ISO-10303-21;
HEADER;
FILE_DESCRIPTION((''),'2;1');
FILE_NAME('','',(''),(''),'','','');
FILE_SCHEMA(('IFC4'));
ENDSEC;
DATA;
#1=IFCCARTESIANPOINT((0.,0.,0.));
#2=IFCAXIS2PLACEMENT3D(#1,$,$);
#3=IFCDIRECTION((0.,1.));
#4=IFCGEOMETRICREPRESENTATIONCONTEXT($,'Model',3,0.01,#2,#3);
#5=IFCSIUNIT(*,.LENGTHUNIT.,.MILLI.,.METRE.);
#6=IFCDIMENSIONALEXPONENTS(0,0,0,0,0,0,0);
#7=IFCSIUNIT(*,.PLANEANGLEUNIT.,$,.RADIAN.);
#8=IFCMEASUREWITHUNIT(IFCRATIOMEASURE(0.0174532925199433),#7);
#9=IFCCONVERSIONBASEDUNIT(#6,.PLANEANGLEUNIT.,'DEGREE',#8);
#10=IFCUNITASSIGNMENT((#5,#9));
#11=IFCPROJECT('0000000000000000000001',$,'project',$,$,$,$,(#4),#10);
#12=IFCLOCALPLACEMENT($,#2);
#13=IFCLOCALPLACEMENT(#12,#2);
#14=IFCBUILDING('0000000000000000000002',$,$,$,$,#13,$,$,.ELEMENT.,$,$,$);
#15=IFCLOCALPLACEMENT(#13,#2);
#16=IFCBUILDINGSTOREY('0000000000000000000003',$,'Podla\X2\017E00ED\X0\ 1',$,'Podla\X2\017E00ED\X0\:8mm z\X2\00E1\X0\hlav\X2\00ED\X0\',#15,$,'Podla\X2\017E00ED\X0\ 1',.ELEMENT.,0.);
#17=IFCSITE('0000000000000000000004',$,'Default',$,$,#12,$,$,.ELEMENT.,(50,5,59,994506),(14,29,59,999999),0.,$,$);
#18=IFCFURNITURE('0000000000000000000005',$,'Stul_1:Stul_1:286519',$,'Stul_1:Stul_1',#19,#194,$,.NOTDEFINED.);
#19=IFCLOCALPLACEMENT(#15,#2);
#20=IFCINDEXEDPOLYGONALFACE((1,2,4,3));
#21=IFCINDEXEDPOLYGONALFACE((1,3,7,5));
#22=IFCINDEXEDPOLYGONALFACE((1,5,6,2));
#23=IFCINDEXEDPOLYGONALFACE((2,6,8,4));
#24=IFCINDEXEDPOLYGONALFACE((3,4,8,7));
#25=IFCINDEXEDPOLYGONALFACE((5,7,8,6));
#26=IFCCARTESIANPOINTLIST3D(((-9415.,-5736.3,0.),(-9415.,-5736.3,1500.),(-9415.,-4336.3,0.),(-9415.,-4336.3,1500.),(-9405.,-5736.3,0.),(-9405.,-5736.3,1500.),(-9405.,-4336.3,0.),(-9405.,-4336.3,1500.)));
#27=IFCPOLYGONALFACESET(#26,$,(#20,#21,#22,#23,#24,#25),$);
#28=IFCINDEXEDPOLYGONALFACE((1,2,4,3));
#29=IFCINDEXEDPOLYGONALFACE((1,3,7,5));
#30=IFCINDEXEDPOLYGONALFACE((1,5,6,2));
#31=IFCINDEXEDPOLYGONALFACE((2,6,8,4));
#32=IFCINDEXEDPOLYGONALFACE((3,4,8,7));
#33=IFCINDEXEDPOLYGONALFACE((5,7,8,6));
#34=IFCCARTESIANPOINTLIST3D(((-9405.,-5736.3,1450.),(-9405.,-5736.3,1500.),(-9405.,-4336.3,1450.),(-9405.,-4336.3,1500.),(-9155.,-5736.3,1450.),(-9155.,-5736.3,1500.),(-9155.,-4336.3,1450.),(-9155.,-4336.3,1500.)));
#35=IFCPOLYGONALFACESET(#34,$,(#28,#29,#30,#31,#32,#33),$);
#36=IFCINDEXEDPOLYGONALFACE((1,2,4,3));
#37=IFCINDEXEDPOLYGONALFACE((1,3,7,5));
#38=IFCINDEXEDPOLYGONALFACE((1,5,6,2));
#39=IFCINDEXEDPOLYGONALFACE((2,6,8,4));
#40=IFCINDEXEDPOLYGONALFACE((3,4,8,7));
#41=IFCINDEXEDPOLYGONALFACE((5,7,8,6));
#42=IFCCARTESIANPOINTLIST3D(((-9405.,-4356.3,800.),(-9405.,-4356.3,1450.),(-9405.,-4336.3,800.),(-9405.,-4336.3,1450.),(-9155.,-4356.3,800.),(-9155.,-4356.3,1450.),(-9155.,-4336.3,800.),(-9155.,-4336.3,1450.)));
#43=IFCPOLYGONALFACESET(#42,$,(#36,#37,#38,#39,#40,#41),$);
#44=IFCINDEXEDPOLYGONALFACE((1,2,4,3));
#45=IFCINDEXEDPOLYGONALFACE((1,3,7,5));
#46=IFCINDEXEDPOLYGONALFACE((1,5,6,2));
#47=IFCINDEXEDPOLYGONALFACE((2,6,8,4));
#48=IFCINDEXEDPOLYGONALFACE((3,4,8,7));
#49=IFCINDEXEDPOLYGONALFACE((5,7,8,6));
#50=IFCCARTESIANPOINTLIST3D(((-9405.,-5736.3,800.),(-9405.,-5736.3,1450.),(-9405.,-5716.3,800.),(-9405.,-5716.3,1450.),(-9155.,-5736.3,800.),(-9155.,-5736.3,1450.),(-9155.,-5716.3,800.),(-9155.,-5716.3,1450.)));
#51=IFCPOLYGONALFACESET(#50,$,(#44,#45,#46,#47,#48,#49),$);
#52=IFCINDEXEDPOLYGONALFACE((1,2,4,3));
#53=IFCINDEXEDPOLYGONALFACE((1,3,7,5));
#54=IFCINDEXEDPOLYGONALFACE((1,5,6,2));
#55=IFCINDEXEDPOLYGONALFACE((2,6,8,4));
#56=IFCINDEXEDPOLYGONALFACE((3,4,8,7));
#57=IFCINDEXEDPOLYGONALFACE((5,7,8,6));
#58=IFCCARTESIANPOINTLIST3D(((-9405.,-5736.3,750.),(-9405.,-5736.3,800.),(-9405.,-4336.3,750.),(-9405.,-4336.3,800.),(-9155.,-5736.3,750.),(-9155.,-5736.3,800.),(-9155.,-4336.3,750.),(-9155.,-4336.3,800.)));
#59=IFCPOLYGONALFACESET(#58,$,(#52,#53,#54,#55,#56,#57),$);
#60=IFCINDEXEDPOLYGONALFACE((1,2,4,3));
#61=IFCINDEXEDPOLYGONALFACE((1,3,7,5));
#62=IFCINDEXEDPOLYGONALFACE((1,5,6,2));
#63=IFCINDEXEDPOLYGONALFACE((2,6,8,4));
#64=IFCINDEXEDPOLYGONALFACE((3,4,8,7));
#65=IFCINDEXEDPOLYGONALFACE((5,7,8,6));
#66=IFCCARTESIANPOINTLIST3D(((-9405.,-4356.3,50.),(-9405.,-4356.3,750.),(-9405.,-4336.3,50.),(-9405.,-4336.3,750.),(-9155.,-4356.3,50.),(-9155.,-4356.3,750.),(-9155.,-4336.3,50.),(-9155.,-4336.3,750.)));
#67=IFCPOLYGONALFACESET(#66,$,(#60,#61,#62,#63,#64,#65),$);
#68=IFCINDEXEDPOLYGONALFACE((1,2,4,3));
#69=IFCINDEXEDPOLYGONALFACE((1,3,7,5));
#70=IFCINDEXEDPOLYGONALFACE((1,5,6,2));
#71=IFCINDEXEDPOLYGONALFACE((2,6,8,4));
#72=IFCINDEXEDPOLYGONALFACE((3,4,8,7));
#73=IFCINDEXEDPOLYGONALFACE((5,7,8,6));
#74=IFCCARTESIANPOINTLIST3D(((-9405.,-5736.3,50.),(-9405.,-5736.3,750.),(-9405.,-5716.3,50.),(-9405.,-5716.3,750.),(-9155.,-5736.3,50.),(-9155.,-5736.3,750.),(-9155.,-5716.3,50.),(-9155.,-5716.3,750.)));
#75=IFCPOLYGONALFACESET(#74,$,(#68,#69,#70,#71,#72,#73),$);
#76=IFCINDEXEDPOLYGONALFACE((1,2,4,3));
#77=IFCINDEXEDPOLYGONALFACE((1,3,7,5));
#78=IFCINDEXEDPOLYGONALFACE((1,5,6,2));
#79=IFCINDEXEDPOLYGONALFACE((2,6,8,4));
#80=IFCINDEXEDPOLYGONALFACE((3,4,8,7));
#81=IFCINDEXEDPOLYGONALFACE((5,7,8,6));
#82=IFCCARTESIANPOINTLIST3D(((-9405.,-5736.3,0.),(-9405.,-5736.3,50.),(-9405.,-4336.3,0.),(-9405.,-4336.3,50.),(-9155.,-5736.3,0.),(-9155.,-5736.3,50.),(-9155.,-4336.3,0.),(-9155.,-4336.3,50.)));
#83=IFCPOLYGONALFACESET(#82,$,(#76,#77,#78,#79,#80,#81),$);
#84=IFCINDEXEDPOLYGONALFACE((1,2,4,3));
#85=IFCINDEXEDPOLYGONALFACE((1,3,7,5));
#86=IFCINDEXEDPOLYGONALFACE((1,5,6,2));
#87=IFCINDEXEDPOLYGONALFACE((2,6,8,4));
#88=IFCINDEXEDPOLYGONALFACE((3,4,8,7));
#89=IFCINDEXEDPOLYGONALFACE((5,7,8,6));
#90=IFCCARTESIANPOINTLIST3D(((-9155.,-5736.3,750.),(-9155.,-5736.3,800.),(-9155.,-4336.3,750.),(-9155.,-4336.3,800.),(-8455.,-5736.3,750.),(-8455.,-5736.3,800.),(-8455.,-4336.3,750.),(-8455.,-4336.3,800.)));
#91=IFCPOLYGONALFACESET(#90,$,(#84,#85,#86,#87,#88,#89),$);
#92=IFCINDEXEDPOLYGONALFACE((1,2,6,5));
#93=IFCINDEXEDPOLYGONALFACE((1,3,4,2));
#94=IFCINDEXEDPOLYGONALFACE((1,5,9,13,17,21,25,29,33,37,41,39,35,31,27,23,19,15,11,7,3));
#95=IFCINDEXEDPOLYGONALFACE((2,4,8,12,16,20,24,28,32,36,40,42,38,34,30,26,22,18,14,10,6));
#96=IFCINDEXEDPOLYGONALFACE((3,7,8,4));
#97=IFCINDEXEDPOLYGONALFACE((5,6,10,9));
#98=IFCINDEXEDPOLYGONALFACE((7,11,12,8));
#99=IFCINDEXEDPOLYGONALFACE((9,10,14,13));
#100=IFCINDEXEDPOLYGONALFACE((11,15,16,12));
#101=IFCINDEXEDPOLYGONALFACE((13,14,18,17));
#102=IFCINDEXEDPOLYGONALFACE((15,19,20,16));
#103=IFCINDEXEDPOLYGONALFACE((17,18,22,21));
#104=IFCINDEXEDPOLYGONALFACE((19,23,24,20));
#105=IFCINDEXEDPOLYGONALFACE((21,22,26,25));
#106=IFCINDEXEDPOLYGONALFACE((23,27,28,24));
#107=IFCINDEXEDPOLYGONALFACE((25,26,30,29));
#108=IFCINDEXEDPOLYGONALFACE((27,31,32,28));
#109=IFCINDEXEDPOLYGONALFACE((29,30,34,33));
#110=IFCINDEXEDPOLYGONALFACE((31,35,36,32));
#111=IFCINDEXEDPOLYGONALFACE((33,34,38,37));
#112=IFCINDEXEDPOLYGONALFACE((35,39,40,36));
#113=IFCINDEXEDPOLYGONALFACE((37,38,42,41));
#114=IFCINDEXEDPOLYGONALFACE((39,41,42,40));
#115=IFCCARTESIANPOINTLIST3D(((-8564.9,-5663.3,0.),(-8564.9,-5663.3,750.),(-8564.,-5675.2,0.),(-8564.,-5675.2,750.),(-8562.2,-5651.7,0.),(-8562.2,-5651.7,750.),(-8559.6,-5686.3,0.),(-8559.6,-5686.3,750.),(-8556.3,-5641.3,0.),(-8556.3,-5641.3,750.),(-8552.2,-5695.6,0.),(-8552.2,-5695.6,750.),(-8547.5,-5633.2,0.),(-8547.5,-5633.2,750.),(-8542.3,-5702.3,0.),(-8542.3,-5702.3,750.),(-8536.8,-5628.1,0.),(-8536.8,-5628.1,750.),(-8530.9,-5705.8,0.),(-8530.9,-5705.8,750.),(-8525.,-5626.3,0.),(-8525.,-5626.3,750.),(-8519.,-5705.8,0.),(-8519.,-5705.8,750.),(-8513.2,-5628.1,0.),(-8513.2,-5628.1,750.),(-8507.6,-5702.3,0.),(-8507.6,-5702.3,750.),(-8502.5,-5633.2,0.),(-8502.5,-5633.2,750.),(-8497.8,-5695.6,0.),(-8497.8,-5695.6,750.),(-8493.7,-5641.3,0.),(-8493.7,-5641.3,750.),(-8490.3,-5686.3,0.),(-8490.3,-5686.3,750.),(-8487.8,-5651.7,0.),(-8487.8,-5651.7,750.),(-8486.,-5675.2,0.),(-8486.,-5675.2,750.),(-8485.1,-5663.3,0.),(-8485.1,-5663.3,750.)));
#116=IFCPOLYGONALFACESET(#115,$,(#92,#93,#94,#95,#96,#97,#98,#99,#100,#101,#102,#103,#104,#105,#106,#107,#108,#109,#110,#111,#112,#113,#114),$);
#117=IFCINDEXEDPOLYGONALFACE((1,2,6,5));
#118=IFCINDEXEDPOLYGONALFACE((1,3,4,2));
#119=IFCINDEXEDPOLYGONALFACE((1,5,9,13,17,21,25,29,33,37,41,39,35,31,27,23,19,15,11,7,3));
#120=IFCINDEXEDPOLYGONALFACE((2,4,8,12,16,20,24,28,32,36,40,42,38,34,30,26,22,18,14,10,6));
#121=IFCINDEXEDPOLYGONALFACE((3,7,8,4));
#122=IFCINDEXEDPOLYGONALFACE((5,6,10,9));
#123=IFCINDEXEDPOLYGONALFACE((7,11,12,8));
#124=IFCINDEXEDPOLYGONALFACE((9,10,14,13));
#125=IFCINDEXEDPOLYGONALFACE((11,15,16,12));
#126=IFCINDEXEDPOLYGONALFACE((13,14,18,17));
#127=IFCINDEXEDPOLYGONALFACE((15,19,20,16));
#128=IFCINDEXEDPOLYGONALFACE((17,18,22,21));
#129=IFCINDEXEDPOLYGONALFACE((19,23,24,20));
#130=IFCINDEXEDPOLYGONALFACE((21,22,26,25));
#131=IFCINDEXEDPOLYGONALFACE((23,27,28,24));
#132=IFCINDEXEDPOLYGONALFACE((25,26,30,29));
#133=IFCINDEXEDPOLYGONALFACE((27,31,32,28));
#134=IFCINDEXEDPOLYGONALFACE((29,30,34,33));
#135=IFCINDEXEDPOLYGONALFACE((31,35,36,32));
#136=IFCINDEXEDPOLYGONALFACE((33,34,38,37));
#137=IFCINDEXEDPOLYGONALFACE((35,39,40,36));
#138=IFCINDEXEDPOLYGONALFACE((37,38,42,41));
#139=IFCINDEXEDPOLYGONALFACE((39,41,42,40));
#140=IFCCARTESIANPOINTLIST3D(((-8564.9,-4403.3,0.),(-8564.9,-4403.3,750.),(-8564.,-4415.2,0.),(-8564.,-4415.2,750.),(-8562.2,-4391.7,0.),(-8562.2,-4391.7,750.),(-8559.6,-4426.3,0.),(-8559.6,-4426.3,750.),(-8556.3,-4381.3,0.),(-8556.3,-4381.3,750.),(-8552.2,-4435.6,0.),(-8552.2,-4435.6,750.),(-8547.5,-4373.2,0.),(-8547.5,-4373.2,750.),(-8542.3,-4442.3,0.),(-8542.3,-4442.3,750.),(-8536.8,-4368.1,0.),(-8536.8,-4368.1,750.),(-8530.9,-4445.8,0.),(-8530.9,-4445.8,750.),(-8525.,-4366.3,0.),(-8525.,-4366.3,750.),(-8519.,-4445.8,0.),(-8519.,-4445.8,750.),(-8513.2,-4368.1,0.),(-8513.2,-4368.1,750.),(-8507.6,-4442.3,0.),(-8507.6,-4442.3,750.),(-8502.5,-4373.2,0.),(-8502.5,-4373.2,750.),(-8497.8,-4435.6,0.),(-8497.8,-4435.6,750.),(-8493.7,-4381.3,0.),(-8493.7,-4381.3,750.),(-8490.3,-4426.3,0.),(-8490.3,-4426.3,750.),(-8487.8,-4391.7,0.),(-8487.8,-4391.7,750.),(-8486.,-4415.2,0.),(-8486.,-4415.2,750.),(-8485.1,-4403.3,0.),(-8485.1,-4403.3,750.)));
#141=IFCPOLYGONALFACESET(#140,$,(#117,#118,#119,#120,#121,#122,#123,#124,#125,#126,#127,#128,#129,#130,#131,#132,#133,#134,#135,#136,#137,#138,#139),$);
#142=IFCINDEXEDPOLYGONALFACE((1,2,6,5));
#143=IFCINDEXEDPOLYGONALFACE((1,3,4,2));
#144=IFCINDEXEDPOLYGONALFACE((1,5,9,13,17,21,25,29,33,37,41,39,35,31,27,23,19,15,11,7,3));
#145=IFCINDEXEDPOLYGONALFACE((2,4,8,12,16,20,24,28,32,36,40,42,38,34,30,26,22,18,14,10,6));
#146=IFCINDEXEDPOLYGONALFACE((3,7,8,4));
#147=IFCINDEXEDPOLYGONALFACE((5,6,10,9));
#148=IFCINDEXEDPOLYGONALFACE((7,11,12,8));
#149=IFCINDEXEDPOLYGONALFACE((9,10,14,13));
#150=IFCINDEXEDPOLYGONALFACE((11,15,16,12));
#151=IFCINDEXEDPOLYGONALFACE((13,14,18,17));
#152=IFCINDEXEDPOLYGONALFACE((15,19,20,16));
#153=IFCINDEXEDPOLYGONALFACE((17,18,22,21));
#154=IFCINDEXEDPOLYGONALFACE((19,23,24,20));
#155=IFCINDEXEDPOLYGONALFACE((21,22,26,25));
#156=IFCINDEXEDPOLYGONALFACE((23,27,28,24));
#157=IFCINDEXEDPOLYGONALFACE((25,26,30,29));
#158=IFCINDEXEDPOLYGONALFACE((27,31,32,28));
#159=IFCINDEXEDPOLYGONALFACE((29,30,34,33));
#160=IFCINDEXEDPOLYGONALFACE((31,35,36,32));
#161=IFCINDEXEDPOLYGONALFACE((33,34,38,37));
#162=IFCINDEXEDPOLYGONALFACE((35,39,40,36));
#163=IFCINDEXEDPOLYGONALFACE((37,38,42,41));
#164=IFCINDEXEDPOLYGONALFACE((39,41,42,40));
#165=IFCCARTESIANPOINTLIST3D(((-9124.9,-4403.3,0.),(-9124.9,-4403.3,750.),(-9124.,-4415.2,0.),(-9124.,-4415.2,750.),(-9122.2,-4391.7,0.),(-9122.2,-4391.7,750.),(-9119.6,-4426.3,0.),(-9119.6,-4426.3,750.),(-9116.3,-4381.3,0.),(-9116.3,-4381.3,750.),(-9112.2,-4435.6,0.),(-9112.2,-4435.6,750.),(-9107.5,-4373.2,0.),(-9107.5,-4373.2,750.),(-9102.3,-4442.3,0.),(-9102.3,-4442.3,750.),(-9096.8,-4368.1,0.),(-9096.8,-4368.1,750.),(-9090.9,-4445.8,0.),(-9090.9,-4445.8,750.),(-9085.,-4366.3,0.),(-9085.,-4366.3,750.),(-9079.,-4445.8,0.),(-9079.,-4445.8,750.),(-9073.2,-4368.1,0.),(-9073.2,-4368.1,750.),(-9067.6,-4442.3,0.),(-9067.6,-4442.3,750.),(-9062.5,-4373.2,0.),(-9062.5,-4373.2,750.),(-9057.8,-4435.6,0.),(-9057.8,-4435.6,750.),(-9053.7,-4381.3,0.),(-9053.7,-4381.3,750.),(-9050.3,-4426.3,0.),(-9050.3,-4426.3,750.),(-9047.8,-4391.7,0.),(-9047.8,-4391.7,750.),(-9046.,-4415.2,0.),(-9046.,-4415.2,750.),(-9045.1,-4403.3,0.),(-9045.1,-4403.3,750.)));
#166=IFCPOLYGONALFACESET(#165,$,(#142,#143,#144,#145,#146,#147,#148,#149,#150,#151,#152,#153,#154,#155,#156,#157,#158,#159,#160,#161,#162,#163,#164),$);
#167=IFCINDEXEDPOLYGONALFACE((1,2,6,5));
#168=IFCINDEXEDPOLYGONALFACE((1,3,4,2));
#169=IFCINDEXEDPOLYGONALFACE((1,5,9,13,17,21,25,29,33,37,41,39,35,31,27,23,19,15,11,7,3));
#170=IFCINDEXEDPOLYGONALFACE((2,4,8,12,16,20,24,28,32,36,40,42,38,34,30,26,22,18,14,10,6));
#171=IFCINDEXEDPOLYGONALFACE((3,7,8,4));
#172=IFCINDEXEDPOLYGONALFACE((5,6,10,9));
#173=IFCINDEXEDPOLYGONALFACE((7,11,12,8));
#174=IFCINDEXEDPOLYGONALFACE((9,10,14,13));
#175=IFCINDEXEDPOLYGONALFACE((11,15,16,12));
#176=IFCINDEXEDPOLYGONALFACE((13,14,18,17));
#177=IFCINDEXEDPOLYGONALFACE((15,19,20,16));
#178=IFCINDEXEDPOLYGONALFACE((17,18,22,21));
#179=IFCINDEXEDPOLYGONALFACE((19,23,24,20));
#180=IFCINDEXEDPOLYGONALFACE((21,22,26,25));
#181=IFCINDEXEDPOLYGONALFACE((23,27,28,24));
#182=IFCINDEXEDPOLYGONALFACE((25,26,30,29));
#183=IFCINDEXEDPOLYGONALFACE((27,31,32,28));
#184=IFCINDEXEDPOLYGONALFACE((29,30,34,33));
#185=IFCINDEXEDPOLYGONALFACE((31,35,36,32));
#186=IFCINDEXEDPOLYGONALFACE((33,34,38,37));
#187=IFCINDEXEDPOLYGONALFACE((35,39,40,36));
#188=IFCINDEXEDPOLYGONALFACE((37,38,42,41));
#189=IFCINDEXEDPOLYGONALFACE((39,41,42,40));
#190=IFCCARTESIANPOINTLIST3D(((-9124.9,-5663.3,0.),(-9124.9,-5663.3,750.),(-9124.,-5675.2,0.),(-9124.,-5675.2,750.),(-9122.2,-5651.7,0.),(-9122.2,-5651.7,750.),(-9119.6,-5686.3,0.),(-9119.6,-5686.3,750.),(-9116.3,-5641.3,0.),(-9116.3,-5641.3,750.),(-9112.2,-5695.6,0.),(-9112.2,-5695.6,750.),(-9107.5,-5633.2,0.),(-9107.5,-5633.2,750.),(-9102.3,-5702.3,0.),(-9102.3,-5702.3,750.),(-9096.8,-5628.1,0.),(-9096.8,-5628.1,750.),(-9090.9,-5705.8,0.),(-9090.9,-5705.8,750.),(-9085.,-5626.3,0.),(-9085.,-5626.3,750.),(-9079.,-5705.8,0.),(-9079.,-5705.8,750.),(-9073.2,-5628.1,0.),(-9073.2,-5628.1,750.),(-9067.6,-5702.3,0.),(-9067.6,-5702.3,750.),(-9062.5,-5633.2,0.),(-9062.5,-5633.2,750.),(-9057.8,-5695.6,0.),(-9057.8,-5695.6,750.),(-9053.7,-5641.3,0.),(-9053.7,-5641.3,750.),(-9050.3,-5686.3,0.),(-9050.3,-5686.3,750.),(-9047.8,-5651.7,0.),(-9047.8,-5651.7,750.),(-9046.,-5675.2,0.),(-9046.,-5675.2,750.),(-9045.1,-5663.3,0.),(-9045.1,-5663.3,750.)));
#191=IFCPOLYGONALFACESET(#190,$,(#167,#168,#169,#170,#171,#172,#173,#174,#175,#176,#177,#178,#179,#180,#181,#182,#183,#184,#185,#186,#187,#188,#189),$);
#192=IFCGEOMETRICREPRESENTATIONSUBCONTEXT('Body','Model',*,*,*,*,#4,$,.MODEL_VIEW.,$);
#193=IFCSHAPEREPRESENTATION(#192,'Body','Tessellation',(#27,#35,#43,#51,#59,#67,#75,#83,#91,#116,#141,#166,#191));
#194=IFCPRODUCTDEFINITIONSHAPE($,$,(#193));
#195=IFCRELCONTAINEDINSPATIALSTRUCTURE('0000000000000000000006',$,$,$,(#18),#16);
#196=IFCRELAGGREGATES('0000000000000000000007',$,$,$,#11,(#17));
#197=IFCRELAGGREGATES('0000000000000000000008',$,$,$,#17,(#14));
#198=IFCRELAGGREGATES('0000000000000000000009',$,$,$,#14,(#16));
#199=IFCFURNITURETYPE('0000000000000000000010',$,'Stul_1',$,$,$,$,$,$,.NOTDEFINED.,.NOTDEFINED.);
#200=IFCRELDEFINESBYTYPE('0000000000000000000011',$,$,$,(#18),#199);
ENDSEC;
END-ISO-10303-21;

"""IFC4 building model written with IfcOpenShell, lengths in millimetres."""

from ifc_helpers import new_model, entity, si_unit, converted_unit, direction, frame, frame_2d, origin, origin_2d_with_axis, place, context, subcontext, project, spatial, rectangle, circle, extrude, source, transform, mapped, type_object, type_shapes, element, save


model = new_model("IFC4")

# Units and contexts
model_context = context("Model", 3, precision=0.01, world=origin(), true_north=direction((0.0, 1.0)))
body_context = subcontext(model_context, "Body", "Model", "MODEL_VIEW")
ifc_project = project(units=[si_unit("LENGTHUNIT", "METRE", prefix="MILLI"), converted_unit("PLANEANGLEUNIT", "DEGREE", entity("IfcRatioMeasure", 0.0174532925199433), si_unit("PLANEANGLEUNIT", "RADIAN"), dimensions=[0, 0, 0, 0, 0, 0, 0])], contexts=[model_context])

# Site, building, storey
site_placement = place(None, origin())
site = spatial("IfcSite", under=ifc_project, at=site_placement, Name="Default", CompositionType="ELEMENT", RefLatitude=(50, 5, 59, 994506), RefLongitude=(14, 29, 59, 999999), RefElevation=0.0)
building_placement = place(site_placement, origin())
building = spatial("IfcBuilding", under=site, at=building_placement, CompositionType="ELEMENT")
storey_placement = place(building_placement, origin())
storey = spatial("IfcBuildingStorey", under=building, at=storey_placement, Name="Podlaží 1", ObjectType="Podlaží:8mm záhlaví", LongName="Podlaží 1", CompositionType="ELEMENT", Elevation=0.0)

# Furniture
furniture_type = type_object("IfcFurnitureType", Name="Stul_1", AssemblyPlace="NOTDEFINED", PredefinedType="NOTDEFINED")
shared_shape_1 = source(origin(), body_context, "Body", "SweptSolid", [
    extrude(rectangle(XDim=1400.0, YDim=10.0, at=origin_2d_with_axis()), frame((0.0, 605.0, 0.0), z_axis=(0.0, 0.0, 1.0), x_axis=(-1.0, 0.0, 0.0)), (0.0, 0.0, 1.0), 1500.0),
    extrude(rectangle(XDim=1400.0, YDim=250.0, at=frame_2d((0.0, 0.0), x_axis=(1.0, 0.0))), frame((0.0, 475.0, 1450.0), z_axis=(0.0, 0.0, 1.0), x_axis=(-1.0, 0.0, 0.0)), (0.0, 0.0, 1.0), 50.0),
    extrude(rectangle(XDim=20.0, YDim=250.0, at=origin_2d_with_axis()), frame((690.0, 475.0, 800.0), z_axis=(0.0, 0.0, 1.0), x_axis=(-1.0, 0.0, 0.0)), (0.0, 0.0, 1.0), 650.0),
    extrude(rectangle(XDim=20.0, YDim=250.0, at=frame_2d((0.0, 0.0), x_axis=(1.0, 0.0))), frame((-690.0, 475.0, 800.0), z_axis=(0.0, 0.0, 1.0), x_axis=(-1.0, 0.0, 0.0)), (0.0, 0.0, 1.0), 650.0),
    extrude(rectangle(XDim=1400.0, YDim=250.0, at=origin_2d_with_axis()), frame((0.0, 475.0, 750.0), z_axis=(0.0, 0.0, 1.0), x_axis=(-1.0, 0.0, 0.0)), (0.0, 0.0, 1.0), 50.0),
    extrude(rectangle(XDim=20.0, YDim=250.0, at=origin_2d_with_axis()), frame((690.0, 475.0, 50.0), z_axis=(0.0, 0.0, 1.0), x_axis=(-1.0, 0.0, 0.0)), (0.0, 0.0, 1.0), 700.0),
    extrude(rectangle(XDim=20.0, YDim=250.0, at=frame_2d((0.0, 0.0), x_axis=(1.0, 0.0))), frame((-690.0, 475.0, 50.0), z_axis=(0.0, 0.0, 1.0), x_axis=(-1.0, 0.0, 0.0)), (0.0, 0.0, 1.0), 700.0),
    extrude(rectangle(XDim=1400.0, YDim=250.0, at=origin_2d_with_axis()), frame((0.0, 475.0, 0.0), z_axis=(0.0, 0.0, 1.0), x_axis=(-1.0, 0.0, 0.0)), (0.0, 0.0, 1.0), 50.0),
    extrude(rectangle(XDim=1400.0, YDim=700.0, at=origin_2d_with_axis()), frame((0.0, 0.0, 750.0), z_axis=(0.0, 0.0, 1.0), x_axis=(-1.0, 0.0, 0.0)), (0.0, 0.0, 1.0), 50.0),
    extrude(circle(Radius=40.0, at=frame_2d((0.0, 0.0), x_axis=(1.0, 0.0))), frame((-630.0, -280.0, 0.0)), (0.0, 0.0, 1.0), 750.0),
    extrude(circle(Radius=40.0, at=frame_2d((0.0, 0.0), x_axis=(1.0, 0.0))), frame((630.0, -280.0, 0.0)), (0.0, 0.0, 1.0), 750.0),
    extrude(circle(Radius=40.0, at=frame_2d((0.0, 0.0), x_axis=(1.0, 0.0))), frame((630.0, 280.0, 0.0)), (0.0, 0.0, 1.0), 750.0),
    extrude(circle(Radius=40.0, at=frame_2d((0.0, 0.0), x_axis=(1.0, 0.0))), frame((-630.0, 280.0, 0.0)), (0.0, 0.0, 1.0), 750.0),
])
type_shapes(furniture_type, [shared_shape_1])
for number, where, z_axis, x_axis, name in (
    (1, (-8805.0, -5036.3, 0.0), (0.0, 0.0, 1.0), (0.0, 1.0, 0.0), "Stul_1:Stul_1:286519"),
):
    element("IfcFurniture", number, at=place(storey_placement, frame(where, z_axis=z_axis, x_axis=x_axis)), inside=storey, type_object=furniture_type, Name=name, ObjectType="Stul_1:Stul_1", PredefinedType="NOTDEFINED", context=body_context, shape_type="MappedRepresentation", body=[
        mapped(shared_shape_1, transform((0.0, 0.0, 0.0), scale=1.0)),
    ])

save(model, "model.ifc")
